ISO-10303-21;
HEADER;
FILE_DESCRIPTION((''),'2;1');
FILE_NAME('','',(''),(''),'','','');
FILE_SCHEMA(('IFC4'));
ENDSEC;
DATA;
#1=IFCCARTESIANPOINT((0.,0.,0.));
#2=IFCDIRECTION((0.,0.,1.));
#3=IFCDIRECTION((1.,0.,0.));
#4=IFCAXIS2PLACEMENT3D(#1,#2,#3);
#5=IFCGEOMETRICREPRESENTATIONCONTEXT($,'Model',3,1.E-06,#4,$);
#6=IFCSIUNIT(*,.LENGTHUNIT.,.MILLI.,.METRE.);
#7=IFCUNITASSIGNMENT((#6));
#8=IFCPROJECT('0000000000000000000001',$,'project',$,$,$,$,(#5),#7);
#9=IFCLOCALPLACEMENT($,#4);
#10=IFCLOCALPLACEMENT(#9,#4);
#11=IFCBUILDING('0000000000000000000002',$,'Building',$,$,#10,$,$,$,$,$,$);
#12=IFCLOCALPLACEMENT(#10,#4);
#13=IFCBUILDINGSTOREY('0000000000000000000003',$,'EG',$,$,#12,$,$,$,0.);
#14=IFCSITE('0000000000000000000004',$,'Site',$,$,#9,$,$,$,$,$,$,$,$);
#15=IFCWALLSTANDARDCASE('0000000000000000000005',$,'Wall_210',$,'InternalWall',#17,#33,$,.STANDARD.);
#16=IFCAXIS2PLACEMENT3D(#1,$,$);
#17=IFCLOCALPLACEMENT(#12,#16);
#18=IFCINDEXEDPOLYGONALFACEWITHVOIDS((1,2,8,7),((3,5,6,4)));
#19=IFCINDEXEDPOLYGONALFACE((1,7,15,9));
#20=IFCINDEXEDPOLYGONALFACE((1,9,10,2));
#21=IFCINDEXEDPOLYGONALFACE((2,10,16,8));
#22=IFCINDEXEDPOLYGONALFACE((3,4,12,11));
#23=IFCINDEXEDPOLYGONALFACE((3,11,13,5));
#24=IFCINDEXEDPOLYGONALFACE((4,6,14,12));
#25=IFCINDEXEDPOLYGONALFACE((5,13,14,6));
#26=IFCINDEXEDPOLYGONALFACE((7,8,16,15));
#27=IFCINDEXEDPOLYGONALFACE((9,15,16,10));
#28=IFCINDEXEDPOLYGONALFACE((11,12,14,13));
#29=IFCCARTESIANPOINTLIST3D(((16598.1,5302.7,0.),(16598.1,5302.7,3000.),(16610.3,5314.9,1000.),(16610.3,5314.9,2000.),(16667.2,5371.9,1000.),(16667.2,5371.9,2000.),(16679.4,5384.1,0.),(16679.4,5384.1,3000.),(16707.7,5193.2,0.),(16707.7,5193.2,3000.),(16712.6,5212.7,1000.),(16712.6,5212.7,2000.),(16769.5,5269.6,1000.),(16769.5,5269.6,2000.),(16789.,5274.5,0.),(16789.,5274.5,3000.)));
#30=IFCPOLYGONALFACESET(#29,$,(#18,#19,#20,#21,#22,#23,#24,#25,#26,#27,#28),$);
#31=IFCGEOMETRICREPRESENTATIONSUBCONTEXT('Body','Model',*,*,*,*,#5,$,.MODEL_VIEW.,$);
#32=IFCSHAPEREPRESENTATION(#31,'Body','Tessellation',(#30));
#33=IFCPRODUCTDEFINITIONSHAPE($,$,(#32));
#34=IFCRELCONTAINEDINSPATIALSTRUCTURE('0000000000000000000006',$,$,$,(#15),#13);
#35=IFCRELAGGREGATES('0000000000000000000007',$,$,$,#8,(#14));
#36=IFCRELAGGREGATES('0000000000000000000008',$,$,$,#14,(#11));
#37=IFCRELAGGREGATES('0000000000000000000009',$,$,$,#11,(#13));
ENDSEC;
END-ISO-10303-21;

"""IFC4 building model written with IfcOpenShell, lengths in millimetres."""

from ifc_helpers import new_model, si_unit, frame, origin_with_axes, place, context, subcontext, project, spatial, rectangle, extrude, element, save


model = new_model("IFC4")

# Units and contexts
model_context = context("Model", 3, precision=1e-06, world=origin_with_axes())
body_context = subcontext(model_context, "Body", "Model", "MODEL_VIEW")
ifc_project = project(units=[si_unit("LENGTHUNIT", "METRE", prefix="MILLI")], contexts=[model_context])

# Site, building, storey
site_placement = place(None, origin_with_axes())
site = spatial("IfcSite", under=ifc_project, at=site_placement, Name="Site")
building_placement = place(site_placement, origin_with_axes())
building = spatial("IfcBuilding", under=site, at=building_placement, Name="Building")
storey_placement = place(building_placement, origin_with_axes())
storey = spatial("IfcBuildingStorey", under=building, at=storey_placement, Name="EG", Elevation=0.0)

# Wall, opening
wall_1_placement = place(storey_placement, origin_with_axes())
wall_1 = element("IfcWallStandardCase", 1, at=wall_1_placement, inside=storey, Name="Wall_210", ObjectType="InternalWall", PredefinedType="STANDARD", context=body_context, shape_type="SweptSolid", body=[
    extrude(rectangle(XDim=155.0, YDim=115.0), frame((16693.6, 5288.6, 0.0), z_axis=(0.0, 0.0, 1.0), x_axis=(0.707107, -0.707107, 0.0)), (0.0, 0.0, 1.0), 3000.0),
])
opening_1_placement = place(wall_1_placement, origin_with_axes())
element("IfcOpeningElement", 2, at=opening_1_placement, inside=storey, cuts=wall_1, context=body_context, shape_type="SweptSolid", body=[
    extrude(rectangle(XDim=1103.8, YDim=80.5), frame((16350.8, 5631.4, 1000.0), z_axis=(0.0, 0.0, 1.0), x_axis=(0.707107, -0.707107, 0.0)), (0.0, 0.0, 1.0), 1000.0),
])

save(model, "model.ifc")
